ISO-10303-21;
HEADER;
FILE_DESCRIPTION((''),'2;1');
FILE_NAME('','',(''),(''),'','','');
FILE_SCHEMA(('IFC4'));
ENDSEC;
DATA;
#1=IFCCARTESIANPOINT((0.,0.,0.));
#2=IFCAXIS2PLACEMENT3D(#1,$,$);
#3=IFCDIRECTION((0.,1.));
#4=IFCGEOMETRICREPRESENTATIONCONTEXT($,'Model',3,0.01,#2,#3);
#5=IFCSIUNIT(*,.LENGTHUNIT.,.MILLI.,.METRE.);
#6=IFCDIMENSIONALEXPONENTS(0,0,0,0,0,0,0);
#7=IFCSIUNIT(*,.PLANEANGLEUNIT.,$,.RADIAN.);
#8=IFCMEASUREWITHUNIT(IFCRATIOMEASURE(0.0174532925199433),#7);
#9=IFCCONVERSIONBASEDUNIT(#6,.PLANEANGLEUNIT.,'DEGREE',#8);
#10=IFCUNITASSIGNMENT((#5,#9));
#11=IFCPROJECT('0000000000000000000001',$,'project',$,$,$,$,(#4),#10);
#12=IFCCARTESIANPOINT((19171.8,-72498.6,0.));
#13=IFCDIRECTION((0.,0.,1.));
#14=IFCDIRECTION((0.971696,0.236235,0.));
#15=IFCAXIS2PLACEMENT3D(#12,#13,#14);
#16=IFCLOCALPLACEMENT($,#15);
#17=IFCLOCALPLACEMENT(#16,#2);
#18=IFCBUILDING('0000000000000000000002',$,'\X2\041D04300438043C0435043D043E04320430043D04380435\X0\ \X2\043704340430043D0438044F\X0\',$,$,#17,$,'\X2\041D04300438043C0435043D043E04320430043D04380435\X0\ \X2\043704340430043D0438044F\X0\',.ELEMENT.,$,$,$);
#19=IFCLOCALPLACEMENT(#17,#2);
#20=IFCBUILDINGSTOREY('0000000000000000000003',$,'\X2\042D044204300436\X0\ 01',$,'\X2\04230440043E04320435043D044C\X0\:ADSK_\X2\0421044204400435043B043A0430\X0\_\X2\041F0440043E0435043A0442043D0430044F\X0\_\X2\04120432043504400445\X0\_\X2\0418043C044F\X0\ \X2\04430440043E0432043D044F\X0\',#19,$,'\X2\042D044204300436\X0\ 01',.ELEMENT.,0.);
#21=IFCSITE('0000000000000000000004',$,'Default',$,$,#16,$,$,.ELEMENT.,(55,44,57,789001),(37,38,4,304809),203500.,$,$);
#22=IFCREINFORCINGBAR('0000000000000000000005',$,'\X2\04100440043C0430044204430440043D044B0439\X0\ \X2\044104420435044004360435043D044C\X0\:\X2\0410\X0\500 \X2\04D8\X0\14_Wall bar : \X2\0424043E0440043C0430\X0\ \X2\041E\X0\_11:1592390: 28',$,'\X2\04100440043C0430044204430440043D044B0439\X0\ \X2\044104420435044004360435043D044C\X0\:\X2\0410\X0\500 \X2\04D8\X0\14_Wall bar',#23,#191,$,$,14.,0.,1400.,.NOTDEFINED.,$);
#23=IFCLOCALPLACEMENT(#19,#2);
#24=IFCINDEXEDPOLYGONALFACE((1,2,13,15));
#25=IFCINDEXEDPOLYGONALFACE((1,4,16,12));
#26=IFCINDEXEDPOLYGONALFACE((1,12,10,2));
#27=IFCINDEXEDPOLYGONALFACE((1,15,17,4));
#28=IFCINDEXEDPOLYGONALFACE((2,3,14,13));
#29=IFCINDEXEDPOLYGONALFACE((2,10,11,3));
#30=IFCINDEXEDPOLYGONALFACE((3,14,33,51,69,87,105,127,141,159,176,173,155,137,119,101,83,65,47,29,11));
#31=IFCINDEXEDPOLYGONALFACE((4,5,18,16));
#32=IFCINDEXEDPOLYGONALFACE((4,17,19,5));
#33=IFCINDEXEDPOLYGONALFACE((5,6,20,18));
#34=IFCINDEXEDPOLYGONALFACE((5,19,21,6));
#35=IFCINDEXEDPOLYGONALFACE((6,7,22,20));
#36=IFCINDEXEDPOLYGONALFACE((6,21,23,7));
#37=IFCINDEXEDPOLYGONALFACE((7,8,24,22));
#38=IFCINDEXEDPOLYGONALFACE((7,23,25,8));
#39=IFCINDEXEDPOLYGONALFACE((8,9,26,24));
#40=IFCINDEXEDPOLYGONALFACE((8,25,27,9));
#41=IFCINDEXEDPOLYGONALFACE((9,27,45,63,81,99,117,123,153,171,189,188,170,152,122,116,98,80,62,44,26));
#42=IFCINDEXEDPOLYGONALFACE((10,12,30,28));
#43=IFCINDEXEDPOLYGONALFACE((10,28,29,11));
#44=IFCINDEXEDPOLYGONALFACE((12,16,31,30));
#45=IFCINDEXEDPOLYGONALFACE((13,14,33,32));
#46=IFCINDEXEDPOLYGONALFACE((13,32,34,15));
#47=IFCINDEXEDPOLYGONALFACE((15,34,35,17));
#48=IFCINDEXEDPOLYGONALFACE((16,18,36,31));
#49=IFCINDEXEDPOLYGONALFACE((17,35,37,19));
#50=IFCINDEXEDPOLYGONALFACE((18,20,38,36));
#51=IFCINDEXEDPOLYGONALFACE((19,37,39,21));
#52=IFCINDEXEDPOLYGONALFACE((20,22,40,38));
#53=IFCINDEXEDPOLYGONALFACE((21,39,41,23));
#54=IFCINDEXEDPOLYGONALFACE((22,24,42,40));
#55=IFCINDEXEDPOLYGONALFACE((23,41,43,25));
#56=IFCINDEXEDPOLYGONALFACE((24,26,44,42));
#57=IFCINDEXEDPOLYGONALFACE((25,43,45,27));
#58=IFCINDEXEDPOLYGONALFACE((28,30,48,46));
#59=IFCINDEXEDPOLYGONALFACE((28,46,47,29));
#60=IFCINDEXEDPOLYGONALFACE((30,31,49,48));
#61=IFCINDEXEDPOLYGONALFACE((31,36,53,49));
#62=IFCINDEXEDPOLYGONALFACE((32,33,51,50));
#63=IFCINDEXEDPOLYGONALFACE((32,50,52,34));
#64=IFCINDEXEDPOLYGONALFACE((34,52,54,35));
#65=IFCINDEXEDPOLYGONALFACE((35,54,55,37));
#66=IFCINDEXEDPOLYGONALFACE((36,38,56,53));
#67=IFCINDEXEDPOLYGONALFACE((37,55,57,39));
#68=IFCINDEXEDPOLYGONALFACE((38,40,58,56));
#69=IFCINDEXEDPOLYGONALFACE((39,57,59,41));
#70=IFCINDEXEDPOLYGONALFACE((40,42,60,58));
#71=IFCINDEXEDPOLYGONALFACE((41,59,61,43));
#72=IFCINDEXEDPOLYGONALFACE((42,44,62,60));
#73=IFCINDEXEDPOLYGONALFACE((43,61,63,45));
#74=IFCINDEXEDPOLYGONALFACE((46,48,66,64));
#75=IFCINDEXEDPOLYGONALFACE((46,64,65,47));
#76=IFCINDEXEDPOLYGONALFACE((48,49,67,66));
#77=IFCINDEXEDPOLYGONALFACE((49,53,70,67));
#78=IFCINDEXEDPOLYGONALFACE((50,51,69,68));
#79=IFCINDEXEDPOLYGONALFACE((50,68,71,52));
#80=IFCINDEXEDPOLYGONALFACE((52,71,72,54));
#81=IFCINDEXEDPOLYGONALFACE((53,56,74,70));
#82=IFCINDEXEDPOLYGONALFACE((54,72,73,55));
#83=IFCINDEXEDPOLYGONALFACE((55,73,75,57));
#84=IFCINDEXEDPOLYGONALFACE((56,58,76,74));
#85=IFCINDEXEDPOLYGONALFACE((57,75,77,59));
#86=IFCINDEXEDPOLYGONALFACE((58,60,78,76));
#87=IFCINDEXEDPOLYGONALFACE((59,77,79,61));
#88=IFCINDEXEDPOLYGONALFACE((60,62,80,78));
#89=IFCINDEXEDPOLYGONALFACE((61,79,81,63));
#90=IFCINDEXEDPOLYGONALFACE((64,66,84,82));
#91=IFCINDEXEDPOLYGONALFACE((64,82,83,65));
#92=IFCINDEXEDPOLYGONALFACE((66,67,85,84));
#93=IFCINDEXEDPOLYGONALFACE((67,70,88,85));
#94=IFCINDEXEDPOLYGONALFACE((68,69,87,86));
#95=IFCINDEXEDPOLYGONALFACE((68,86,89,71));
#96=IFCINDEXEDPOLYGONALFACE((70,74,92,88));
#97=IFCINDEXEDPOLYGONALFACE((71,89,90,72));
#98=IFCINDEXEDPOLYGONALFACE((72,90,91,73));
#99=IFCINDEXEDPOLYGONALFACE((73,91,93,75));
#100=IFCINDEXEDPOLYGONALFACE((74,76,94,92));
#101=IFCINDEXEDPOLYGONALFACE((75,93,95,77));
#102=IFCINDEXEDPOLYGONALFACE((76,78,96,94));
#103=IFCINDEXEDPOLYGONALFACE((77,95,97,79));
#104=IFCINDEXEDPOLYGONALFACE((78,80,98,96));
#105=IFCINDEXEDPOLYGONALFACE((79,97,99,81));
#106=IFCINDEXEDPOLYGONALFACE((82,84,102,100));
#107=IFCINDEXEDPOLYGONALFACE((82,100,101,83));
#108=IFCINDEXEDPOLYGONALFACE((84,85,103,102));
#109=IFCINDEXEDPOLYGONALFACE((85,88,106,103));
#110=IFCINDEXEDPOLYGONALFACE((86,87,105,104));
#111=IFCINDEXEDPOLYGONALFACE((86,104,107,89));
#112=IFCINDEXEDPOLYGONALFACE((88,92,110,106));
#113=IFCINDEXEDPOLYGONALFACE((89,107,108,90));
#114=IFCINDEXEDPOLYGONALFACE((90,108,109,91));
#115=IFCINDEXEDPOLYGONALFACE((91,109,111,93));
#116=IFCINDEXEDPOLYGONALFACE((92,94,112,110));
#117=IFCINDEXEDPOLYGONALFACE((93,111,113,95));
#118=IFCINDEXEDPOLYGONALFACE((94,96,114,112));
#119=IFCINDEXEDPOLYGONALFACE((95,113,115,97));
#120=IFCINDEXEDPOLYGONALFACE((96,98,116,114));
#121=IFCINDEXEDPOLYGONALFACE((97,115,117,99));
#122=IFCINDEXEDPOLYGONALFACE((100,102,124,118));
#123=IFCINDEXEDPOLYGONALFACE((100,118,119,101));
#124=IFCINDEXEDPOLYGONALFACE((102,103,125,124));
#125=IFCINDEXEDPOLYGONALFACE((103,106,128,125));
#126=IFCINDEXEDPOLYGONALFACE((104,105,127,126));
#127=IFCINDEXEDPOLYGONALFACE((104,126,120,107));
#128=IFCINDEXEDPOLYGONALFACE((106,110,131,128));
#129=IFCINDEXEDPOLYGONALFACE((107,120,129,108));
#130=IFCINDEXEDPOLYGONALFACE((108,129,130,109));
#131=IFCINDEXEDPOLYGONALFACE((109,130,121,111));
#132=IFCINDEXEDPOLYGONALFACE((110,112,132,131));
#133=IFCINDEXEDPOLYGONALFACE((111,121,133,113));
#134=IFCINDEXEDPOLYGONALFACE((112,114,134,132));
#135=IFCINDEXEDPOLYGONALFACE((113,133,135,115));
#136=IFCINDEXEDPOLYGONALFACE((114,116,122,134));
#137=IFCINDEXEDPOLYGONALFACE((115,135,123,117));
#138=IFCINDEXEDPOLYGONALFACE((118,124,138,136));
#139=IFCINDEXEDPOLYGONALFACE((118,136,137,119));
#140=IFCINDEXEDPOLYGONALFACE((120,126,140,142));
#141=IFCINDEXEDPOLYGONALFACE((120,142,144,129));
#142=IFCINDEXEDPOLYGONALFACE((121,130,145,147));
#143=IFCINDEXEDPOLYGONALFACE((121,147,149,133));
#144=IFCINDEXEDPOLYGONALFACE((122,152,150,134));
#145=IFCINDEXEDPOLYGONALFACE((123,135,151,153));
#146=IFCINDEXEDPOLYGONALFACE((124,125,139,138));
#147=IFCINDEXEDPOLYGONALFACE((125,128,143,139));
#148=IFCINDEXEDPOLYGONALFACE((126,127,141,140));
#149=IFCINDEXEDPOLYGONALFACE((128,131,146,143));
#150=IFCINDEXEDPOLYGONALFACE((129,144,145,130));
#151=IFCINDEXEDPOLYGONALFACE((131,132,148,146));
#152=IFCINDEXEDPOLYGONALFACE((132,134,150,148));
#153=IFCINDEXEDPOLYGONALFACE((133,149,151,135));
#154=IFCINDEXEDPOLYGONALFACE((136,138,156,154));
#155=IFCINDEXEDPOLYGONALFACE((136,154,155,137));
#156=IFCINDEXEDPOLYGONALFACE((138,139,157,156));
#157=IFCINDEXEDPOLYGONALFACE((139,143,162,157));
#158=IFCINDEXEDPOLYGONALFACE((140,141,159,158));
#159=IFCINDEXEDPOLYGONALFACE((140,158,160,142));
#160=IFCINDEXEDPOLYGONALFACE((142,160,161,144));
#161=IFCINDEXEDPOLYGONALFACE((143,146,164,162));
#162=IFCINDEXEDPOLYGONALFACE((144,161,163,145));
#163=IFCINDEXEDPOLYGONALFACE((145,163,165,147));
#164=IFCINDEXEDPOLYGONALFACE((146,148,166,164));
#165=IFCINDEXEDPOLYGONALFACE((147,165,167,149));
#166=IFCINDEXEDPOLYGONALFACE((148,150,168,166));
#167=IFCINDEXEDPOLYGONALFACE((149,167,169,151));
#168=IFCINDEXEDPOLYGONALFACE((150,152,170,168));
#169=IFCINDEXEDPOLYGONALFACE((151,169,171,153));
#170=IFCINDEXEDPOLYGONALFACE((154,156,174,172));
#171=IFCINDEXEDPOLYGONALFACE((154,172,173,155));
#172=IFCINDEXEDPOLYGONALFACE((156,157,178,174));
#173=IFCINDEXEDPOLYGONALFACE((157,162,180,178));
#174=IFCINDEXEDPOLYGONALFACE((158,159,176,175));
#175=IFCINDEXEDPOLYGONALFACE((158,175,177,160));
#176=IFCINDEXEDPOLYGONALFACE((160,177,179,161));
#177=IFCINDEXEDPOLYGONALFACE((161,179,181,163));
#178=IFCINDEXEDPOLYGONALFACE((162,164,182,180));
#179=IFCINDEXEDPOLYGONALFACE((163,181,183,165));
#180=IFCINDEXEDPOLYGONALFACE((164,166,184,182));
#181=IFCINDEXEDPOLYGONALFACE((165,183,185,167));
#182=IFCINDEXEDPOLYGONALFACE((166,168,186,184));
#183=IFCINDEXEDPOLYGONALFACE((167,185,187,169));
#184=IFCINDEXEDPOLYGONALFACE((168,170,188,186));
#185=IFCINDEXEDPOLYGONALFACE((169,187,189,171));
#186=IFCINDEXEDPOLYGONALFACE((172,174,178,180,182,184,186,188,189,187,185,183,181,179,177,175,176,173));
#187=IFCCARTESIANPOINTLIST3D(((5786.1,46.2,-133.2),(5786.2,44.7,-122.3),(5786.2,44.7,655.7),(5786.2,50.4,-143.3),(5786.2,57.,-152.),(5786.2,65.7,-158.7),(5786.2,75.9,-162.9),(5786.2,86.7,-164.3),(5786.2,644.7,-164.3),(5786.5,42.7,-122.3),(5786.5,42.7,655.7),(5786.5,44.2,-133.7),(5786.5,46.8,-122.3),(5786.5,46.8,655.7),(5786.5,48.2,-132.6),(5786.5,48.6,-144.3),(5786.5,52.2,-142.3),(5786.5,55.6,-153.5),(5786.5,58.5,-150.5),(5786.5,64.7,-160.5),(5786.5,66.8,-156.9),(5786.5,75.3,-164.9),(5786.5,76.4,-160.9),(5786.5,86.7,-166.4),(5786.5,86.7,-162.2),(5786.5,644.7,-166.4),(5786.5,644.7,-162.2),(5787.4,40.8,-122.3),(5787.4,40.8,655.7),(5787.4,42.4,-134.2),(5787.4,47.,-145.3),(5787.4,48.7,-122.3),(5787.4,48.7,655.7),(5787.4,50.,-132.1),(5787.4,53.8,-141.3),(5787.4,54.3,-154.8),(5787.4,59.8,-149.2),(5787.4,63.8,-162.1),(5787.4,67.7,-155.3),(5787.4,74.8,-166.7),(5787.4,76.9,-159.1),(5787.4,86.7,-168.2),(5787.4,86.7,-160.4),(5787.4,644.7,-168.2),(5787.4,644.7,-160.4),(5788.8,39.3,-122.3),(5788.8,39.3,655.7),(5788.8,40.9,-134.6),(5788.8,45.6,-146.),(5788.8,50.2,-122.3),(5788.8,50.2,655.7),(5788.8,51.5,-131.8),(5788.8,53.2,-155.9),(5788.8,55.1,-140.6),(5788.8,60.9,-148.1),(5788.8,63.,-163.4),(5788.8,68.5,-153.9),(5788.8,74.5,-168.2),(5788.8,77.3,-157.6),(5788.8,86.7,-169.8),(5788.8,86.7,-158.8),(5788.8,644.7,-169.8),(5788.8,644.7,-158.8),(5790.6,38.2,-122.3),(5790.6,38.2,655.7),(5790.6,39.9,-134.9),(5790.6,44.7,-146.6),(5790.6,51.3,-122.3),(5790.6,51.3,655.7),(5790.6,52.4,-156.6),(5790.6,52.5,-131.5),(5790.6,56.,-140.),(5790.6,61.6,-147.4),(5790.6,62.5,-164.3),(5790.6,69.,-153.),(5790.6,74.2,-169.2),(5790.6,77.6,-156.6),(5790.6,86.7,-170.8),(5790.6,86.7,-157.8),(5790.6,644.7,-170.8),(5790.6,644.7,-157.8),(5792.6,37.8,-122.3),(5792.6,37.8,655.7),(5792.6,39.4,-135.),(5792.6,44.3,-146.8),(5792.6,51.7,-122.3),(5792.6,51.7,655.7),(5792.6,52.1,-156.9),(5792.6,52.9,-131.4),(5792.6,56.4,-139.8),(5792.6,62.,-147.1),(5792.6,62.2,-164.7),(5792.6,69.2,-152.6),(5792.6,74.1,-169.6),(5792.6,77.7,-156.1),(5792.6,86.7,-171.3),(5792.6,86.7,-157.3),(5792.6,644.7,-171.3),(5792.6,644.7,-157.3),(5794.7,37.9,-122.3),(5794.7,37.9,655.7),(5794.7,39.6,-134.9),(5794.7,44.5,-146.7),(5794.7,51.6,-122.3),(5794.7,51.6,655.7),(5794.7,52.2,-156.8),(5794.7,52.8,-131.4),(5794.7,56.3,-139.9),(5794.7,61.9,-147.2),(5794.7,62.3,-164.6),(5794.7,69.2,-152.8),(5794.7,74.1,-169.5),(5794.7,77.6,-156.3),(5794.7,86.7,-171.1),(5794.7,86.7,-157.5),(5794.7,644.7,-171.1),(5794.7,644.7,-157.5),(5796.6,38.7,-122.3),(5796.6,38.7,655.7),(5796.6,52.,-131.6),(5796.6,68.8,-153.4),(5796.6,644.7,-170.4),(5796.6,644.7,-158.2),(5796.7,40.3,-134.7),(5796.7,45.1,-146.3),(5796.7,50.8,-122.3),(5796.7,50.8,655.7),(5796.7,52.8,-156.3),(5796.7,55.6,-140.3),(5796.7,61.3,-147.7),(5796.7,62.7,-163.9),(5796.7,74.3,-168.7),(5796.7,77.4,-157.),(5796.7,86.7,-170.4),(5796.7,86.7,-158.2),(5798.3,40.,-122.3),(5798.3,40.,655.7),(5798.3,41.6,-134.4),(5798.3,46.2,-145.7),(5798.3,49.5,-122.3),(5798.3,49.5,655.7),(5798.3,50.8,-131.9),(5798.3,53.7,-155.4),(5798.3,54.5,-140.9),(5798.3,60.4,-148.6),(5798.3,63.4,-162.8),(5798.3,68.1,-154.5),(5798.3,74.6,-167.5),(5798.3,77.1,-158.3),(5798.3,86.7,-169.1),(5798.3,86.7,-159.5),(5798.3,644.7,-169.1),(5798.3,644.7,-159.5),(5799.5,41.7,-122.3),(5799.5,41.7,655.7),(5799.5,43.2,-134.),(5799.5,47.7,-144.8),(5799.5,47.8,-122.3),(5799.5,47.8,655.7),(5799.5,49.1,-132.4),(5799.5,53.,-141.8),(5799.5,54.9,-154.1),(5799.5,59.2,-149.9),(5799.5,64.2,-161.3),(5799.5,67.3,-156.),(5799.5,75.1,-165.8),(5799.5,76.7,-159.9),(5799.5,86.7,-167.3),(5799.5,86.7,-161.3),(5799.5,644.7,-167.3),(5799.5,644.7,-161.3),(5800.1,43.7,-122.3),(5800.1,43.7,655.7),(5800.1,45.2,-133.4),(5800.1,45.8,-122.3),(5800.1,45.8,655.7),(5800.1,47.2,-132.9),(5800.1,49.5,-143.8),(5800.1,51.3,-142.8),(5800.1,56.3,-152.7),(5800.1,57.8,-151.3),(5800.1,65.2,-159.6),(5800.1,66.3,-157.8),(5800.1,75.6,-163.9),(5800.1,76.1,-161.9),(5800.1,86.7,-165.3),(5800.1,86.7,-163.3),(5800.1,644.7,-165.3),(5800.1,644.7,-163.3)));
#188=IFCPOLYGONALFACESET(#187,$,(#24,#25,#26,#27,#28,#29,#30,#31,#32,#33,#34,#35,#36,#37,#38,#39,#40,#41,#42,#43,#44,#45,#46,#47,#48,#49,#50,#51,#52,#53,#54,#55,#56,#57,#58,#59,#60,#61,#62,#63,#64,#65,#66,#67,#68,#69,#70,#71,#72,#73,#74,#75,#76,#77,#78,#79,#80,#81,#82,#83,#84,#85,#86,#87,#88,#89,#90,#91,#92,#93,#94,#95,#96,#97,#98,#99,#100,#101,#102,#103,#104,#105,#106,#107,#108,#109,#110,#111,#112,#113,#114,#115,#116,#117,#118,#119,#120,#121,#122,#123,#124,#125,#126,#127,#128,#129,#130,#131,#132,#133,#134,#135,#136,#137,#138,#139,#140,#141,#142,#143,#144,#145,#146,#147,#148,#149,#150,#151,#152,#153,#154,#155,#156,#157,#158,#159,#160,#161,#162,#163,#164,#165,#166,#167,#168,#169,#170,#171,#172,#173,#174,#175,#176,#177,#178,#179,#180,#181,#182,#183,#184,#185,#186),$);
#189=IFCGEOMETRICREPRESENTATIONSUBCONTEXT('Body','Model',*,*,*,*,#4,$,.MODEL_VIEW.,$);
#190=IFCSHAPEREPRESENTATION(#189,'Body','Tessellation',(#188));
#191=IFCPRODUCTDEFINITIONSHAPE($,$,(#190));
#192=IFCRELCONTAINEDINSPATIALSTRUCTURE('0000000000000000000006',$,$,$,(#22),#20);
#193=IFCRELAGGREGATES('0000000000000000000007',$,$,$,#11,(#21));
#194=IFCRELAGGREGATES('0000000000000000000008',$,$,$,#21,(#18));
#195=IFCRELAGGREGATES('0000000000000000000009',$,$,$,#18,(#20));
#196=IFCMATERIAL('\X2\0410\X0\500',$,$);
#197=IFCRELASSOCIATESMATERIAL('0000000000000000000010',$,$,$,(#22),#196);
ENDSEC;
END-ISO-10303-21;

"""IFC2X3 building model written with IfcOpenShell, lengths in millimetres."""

from ifc_helpers import new_model, entity, si_unit, converted_unit, direction, frame, origin, place, context, subcontext, project, spatial, material, element, save


model = new_model("IFC2X3")

# Units and contexts
model_context = context("Model", 3, precision=0.01, world=origin(), true_north=direction((0.0, 1.0)))
body_context = subcontext(model_context, "Body", "Model", "MODEL_VIEW")
ifc_project = project(units=[si_unit("LENGTHUNIT", "METRE", prefix="MILLI"), converted_unit("PLANEANGLEUNIT", "DEGREE", entity("IfcRatioMeasure", 0.0174532925199433), si_unit("PLANEANGLEUNIT", "RADIAN"), dimensions=[0, 0, 0, 0, 0, 0, 0])], contexts=[model_context])

# Site, building, storey
site_placement = place(None, frame((19171.8, -72498.6, 0.0), z_axis=(0.0, 0.0, 1.0), x_axis=(0.971696, 0.236235, 0.0)))
site = spatial("IfcSite", under=ifc_project, at=site_placement, Name="Default", CompositionType="ELEMENT", RefLatitude=(55, 44, 57, 789001), RefLongitude=(37, 38, 4, 304809), RefElevation=203500.0)
building_placement = place(site_placement, origin())
building = spatial("IfcBuilding", under=site, at=building_placement, Name="Наименование здания", LongName="Наименование здания", CompositionType="ELEMENT")
storey_placement = place(building_placement, origin())
storey = spatial("IfcBuildingStorey", under=building, at=storey_placement, Name="Этаж 01", ObjectType="Уровень:ADSK_Стрелка_Проектная_Вверх_Имя уровня", LongName="Этаж 01", CompositionType="ELEMENT", Elevation=0.0)

# Reinforcing bar
ifc_material = material(Name="А500")
placement = place(storey_placement, origin())
element("IfcReinforcingBar", 1, at=placement, inside=storey, material=ifc_material, Name="Арматурный стержень:А500 Ә14_Wall bar : Форма О_11:1592390: 28", ObjectType="Арматурный стержень:А500 Ә14_Wall bar", BarLength=1400.0, BarRole="NOTDEFINED", CrossSectionArea=0.0, NominalDiameter=14.0, context=body_context, shape_type="AdvancedSweptSolid", body=[
    entity("IfcSweptDiskSolid", entity("IfcCompositeCurve", [entity("IfcCompositeCurveSegment", "CONTINUOUS", True, entity("IfcPolyline", [entity("IfcCartesianPoint", [5793.1, 44.7, 655.7]), entity("IfcCartesianPoint", [5793.1, 44.7, -122.3])])), entity("IfcCompositeCurveSegment", "CONTINUOUS", True, entity("IfcTrimmedCurve", entity("IfcCircle", entity("IfcAxis2Placement3D", entity("IfcCartesianPoint", [5793.1, 86.7, -122.3]), entity("IfcDirection", [1.0, 0.0, 0.0]), entity("IfcDirection", [0.0, 0.0, -1.0])), 42.0), [entity("IfcParameterValue", 270.0)], [entity("IfcParameterValue", 360.0)], True, "PARAMETER")), entity("IfcCompositeCurveSegment", "CONTINUOUS", True, entity("IfcPolyline", [entity("IfcCartesianPoint", [5793.1, 86.7, -164.3]), entity("IfcCartesianPoint", [5793.1, 644.7, -164.3])]))], False), 7.0, None, 0.0, 92.0),
])

save(model, "model.ifc")
